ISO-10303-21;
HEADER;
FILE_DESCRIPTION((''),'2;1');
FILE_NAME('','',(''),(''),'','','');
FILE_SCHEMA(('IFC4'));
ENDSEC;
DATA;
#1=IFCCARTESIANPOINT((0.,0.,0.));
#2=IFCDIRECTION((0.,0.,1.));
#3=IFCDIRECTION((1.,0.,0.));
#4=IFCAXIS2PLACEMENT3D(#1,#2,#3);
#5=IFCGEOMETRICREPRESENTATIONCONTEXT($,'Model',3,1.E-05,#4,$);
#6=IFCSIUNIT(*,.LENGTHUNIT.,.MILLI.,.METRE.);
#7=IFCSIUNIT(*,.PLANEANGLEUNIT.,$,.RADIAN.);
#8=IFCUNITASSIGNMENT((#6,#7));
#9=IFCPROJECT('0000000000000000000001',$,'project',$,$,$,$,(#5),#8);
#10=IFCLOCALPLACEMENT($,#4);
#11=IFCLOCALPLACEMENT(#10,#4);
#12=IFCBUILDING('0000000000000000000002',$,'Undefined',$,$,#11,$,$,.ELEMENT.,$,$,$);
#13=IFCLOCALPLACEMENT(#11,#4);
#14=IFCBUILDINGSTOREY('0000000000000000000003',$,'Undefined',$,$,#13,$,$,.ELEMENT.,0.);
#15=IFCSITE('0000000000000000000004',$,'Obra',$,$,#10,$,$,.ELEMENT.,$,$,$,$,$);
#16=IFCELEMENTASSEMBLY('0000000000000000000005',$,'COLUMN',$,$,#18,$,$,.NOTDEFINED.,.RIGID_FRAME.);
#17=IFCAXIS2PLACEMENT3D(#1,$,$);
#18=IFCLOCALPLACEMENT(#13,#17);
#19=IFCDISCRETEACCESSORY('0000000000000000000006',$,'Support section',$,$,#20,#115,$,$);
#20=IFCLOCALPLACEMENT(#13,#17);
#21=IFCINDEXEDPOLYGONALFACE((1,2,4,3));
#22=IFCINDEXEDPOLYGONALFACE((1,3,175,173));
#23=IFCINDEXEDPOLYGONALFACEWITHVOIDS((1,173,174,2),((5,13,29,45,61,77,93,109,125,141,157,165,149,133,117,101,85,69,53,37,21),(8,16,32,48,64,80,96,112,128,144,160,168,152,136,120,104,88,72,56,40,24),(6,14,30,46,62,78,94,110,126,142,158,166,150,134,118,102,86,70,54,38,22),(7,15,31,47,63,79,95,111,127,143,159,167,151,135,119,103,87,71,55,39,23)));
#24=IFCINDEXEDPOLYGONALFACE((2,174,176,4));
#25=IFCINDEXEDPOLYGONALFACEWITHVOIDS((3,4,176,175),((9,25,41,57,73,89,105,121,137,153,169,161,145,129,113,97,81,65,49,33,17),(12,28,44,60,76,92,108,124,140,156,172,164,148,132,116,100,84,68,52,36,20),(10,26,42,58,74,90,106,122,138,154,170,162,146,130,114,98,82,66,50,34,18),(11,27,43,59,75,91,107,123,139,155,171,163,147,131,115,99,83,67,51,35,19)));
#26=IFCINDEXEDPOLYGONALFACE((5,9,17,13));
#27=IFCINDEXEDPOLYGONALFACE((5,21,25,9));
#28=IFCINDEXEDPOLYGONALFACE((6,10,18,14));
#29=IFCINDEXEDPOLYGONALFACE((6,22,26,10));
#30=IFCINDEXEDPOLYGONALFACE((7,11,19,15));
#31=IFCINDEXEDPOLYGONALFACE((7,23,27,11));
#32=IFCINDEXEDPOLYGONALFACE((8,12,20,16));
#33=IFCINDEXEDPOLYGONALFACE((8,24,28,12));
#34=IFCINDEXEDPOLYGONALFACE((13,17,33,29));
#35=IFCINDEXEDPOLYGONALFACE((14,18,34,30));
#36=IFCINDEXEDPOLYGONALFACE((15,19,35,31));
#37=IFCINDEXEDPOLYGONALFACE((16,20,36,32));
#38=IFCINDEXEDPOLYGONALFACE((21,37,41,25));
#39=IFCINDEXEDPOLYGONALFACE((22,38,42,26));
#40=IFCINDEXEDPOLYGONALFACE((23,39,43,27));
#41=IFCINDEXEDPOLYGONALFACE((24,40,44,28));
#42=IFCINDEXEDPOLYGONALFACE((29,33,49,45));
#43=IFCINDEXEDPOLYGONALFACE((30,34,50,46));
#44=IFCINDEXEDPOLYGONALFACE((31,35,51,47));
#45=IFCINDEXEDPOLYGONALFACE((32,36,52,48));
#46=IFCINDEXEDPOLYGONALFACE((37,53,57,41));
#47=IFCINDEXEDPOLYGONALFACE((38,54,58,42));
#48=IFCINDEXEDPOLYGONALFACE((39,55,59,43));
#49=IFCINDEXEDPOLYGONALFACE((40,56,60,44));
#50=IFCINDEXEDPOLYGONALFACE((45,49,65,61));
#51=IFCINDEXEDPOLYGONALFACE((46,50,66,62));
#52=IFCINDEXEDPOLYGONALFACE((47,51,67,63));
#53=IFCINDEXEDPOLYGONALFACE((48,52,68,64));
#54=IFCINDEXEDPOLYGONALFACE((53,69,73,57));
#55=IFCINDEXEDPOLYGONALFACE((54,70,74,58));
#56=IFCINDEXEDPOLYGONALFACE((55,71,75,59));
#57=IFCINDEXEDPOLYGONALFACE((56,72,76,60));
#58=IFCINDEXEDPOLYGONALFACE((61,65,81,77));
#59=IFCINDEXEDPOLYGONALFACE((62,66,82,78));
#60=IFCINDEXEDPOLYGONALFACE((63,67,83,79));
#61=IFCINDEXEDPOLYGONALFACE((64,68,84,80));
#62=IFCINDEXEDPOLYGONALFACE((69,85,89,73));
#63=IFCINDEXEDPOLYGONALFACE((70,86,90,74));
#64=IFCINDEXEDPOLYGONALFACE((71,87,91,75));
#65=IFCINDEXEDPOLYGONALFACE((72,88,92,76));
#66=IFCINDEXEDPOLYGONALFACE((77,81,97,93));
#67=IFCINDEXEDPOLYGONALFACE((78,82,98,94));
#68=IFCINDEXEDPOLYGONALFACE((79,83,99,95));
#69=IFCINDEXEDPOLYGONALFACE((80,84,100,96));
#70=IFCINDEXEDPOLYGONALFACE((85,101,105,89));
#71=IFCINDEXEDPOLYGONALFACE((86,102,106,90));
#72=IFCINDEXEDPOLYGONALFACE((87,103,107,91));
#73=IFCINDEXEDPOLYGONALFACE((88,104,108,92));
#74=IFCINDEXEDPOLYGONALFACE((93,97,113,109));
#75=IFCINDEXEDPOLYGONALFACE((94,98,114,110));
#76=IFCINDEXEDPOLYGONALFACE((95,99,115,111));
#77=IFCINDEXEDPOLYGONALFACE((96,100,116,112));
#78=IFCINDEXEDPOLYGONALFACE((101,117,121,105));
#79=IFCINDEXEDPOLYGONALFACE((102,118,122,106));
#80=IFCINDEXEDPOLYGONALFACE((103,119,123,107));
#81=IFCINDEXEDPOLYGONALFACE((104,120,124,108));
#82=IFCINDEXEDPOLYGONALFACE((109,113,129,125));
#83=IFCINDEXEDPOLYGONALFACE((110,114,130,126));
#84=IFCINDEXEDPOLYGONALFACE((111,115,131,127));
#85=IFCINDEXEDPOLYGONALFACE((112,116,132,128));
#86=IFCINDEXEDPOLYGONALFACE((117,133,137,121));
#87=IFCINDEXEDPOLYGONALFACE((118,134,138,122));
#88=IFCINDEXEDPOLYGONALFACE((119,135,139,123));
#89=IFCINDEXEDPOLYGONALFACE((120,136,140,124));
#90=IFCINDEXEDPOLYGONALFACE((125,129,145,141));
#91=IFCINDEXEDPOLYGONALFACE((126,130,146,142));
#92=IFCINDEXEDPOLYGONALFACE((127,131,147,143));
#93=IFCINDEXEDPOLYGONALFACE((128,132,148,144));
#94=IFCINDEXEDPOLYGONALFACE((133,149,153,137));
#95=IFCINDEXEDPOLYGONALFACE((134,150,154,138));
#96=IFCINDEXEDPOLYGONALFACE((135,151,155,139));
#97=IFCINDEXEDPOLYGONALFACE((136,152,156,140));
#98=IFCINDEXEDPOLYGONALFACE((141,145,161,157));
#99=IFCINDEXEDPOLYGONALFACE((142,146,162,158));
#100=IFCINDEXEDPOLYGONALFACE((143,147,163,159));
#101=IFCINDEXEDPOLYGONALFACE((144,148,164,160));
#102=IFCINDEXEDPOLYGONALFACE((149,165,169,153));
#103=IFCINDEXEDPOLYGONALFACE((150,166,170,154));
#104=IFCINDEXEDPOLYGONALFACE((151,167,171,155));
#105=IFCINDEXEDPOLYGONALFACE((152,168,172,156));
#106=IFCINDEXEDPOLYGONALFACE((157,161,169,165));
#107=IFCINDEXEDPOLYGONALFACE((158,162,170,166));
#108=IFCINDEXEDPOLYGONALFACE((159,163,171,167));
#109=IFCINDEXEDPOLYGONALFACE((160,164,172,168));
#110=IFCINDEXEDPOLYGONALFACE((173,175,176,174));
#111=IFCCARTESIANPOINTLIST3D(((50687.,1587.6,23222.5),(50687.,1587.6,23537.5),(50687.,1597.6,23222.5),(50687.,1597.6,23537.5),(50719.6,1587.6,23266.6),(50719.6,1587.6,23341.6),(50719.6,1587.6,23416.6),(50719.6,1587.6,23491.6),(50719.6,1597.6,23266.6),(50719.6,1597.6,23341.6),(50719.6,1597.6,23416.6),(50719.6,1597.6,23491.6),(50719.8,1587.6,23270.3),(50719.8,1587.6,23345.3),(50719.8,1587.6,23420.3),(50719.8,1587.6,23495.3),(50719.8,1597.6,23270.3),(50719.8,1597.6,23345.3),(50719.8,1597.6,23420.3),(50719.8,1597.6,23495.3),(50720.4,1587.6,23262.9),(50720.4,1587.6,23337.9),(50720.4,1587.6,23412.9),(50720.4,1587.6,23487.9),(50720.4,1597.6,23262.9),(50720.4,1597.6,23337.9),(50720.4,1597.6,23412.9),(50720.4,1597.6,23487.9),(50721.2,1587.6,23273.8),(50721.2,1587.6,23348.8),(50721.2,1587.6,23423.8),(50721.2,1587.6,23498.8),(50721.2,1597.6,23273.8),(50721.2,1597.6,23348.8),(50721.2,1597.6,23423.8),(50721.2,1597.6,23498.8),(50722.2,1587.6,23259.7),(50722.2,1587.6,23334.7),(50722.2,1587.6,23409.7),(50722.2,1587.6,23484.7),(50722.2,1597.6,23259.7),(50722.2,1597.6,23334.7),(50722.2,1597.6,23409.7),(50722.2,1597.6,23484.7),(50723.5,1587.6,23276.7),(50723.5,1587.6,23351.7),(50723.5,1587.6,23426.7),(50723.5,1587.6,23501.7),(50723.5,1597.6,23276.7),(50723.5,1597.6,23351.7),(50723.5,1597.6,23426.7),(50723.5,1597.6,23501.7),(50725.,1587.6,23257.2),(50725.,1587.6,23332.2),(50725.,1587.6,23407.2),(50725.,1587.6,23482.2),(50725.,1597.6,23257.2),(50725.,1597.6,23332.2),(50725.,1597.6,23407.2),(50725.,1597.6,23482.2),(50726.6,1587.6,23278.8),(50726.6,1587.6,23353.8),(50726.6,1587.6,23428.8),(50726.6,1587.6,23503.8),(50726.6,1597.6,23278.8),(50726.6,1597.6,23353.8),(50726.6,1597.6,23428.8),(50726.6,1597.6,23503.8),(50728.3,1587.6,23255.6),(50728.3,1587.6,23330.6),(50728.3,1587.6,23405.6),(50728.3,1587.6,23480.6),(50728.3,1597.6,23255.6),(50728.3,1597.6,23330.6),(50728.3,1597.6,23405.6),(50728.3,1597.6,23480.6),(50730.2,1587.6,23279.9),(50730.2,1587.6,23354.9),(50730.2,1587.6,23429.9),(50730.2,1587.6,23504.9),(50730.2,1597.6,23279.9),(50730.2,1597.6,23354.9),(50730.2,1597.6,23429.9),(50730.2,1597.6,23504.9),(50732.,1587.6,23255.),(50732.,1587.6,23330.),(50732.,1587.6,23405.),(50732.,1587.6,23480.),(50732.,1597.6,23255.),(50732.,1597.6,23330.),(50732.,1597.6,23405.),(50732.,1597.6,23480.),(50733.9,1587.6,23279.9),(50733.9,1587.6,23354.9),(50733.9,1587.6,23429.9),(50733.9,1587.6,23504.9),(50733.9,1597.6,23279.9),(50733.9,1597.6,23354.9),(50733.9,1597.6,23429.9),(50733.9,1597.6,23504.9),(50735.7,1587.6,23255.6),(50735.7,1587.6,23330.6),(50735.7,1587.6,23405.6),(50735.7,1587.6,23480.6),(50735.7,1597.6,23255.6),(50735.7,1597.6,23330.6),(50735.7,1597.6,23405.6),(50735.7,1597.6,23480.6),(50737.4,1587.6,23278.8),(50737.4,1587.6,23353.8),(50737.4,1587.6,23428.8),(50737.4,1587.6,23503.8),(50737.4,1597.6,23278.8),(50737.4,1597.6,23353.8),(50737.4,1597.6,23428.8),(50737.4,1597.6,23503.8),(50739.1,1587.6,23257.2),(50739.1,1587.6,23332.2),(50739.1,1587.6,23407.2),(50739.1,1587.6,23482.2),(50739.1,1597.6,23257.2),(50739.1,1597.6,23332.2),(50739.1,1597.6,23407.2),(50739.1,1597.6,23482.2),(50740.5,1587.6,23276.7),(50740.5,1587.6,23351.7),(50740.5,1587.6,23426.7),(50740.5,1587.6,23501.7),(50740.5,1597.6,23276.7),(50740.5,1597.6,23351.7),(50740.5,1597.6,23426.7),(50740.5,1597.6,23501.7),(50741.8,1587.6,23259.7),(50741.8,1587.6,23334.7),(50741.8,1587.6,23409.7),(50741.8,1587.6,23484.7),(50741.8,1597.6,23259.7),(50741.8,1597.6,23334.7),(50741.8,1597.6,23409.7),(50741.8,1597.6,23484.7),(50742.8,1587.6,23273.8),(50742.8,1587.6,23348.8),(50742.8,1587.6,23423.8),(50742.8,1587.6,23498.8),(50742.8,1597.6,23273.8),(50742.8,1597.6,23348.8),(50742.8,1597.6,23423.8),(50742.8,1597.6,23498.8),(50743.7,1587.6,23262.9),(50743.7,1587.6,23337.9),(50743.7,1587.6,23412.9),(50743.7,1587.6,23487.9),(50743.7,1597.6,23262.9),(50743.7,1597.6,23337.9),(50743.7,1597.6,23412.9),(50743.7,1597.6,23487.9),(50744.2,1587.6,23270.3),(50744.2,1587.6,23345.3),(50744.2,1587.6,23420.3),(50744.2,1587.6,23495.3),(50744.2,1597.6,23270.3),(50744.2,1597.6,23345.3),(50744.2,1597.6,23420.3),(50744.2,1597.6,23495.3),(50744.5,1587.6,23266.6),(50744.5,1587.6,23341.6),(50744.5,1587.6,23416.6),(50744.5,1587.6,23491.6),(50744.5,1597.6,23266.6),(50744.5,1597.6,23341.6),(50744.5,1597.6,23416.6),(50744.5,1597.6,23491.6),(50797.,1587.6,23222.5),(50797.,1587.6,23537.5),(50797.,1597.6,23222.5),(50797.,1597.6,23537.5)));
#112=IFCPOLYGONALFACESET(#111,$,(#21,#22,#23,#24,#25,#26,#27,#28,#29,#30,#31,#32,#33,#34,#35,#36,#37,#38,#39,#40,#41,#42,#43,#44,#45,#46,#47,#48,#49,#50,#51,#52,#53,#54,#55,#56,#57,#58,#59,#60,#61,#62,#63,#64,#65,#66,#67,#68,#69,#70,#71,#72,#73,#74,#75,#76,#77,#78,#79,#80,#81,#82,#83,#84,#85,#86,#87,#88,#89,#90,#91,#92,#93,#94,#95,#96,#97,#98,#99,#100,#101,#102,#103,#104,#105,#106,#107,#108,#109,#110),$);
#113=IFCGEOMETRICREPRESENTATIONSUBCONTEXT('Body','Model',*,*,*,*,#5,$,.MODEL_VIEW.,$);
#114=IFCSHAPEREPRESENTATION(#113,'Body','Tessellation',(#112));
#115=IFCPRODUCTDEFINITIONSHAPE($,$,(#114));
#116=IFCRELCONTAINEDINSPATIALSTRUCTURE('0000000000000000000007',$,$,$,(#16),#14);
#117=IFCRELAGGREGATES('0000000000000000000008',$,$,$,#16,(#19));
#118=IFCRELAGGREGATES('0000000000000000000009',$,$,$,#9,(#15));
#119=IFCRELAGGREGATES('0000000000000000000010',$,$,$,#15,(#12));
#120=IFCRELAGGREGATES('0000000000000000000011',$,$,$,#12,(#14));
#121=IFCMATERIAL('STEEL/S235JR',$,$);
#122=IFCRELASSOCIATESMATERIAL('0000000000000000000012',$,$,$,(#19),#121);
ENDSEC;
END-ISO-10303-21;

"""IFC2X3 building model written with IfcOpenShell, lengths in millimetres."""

from ifc_helpers import new_model, si_unit, frame, origin_with_axes, origin_2d_with_axis, place, context, subcontext, project, spatial, rectangle, circle, extrude, source, transform, mapped, material, element, aggregate, save


model = new_model("IFC2X3")

# Units and contexts
model_context = context("Model", 3, precision=1e-05, world=origin_with_axes())
body_context = subcontext(model_context, "Body", "Model", "MODEL_VIEW")
ifc_project = project(units=[si_unit("LENGTHUNIT", "METRE", prefix="MILLI"), si_unit("PLANEANGLEUNIT", "RADIAN")], contexts=[model_context])

# Site, building, storey
site_placement = place(None, origin_with_axes())
site = spatial("IfcSite", under=ifc_project, at=site_placement, Name="Obra", CompositionType="ELEMENT")
building_placement = place(site_placement, origin_with_axes())
building = spatial("IfcBuilding", under=site, at=building_placement, Name="Undefined", CompositionType="ELEMENT")
storey_placement = place(building_placement, origin_with_axes())
storey = spatial("IfcBuildingStorey", under=building, at=storey_placement, Name="Undefined", CompositionType="ELEMENT", Elevation=0.0)

# Shared definitions
ifc_material_1 = material(Name="STEEL/S235JR")

# Element assembly, discrete accessory, opening
assembly_1_placement = place(storey_placement, origin_with_axes())
assembly_1 = element("IfcElementAssembly", 1, at=assembly_1_placement, inside=storey, Name="COLUMN", AssemblyPlace="NOTDEFINED", PredefinedType="RIGID_FRAME")
discrete_accessory_1_placement = place(assembly_1_placement, frame((50742.0, 1592.6, 23222.5), z_axis=(0.0, 0.0, 1.0), x_axis=(1.0, 0.0, 0.0)))
discrete_accessory_1 = element("IfcDiscreteAccessory", 2, at=discrete_accessory_1_placement, material=ifc_material_1, Name="Support section", context=body_context, shape_type="SweptSolid", body=[
    extrude(rectangle(XDim=10.0, YDim=110.0, at=origin_2d_with_axis()), frame((0.0, 0.0, 315.0), z_axis=(0.0, 0.0, -1.0), x_axis=(0.0, 1.0, 0.0)), (0.0, 0.0, 1.0), 315.0),
])
shared_shape_1 = source(origin_with_axes(), body_context, "Body", "SweptSolid", [
    extrude(circle(Radius=12.5, at=origin_2d_with_axis()), frame((0.0, 5.7, 0.0), z_axis=(0.0, 1.0, 0.0), x_axis=(1.0, 0.0, 0.0)), (0.0, 0.0, 1.0), 10.2),
])
opening_1_placement = place(assembly_1_placement, frame((50777.0, 1603.4, 23600.0), z_axis=(-1.0, 0.0, 0.0), x_axis=(0.0, 0.0, -1.0)))
element("IfcOpeningElement", 3, at=opening_1_placement, cuts=discrete_accessory_1, ObjectType="Opening", context=body_context, shape_type="MappedRepresentation", body=[
    mapped(shared_shape_1, transform((107.5, 0.0, 45.0))),
    mapped(shared_shape_1, transform((182.5, 0.0, 45.0))),
    mapped(shared_shape_1, transform((257.5, 0.0, 45.0))),
    mapped(shared_shape_1, transform((332.5, 0.0, 45.0))),
])

aggregate(assembly_1, [discrete_accessory_1])

save(model, "model.ifc")
